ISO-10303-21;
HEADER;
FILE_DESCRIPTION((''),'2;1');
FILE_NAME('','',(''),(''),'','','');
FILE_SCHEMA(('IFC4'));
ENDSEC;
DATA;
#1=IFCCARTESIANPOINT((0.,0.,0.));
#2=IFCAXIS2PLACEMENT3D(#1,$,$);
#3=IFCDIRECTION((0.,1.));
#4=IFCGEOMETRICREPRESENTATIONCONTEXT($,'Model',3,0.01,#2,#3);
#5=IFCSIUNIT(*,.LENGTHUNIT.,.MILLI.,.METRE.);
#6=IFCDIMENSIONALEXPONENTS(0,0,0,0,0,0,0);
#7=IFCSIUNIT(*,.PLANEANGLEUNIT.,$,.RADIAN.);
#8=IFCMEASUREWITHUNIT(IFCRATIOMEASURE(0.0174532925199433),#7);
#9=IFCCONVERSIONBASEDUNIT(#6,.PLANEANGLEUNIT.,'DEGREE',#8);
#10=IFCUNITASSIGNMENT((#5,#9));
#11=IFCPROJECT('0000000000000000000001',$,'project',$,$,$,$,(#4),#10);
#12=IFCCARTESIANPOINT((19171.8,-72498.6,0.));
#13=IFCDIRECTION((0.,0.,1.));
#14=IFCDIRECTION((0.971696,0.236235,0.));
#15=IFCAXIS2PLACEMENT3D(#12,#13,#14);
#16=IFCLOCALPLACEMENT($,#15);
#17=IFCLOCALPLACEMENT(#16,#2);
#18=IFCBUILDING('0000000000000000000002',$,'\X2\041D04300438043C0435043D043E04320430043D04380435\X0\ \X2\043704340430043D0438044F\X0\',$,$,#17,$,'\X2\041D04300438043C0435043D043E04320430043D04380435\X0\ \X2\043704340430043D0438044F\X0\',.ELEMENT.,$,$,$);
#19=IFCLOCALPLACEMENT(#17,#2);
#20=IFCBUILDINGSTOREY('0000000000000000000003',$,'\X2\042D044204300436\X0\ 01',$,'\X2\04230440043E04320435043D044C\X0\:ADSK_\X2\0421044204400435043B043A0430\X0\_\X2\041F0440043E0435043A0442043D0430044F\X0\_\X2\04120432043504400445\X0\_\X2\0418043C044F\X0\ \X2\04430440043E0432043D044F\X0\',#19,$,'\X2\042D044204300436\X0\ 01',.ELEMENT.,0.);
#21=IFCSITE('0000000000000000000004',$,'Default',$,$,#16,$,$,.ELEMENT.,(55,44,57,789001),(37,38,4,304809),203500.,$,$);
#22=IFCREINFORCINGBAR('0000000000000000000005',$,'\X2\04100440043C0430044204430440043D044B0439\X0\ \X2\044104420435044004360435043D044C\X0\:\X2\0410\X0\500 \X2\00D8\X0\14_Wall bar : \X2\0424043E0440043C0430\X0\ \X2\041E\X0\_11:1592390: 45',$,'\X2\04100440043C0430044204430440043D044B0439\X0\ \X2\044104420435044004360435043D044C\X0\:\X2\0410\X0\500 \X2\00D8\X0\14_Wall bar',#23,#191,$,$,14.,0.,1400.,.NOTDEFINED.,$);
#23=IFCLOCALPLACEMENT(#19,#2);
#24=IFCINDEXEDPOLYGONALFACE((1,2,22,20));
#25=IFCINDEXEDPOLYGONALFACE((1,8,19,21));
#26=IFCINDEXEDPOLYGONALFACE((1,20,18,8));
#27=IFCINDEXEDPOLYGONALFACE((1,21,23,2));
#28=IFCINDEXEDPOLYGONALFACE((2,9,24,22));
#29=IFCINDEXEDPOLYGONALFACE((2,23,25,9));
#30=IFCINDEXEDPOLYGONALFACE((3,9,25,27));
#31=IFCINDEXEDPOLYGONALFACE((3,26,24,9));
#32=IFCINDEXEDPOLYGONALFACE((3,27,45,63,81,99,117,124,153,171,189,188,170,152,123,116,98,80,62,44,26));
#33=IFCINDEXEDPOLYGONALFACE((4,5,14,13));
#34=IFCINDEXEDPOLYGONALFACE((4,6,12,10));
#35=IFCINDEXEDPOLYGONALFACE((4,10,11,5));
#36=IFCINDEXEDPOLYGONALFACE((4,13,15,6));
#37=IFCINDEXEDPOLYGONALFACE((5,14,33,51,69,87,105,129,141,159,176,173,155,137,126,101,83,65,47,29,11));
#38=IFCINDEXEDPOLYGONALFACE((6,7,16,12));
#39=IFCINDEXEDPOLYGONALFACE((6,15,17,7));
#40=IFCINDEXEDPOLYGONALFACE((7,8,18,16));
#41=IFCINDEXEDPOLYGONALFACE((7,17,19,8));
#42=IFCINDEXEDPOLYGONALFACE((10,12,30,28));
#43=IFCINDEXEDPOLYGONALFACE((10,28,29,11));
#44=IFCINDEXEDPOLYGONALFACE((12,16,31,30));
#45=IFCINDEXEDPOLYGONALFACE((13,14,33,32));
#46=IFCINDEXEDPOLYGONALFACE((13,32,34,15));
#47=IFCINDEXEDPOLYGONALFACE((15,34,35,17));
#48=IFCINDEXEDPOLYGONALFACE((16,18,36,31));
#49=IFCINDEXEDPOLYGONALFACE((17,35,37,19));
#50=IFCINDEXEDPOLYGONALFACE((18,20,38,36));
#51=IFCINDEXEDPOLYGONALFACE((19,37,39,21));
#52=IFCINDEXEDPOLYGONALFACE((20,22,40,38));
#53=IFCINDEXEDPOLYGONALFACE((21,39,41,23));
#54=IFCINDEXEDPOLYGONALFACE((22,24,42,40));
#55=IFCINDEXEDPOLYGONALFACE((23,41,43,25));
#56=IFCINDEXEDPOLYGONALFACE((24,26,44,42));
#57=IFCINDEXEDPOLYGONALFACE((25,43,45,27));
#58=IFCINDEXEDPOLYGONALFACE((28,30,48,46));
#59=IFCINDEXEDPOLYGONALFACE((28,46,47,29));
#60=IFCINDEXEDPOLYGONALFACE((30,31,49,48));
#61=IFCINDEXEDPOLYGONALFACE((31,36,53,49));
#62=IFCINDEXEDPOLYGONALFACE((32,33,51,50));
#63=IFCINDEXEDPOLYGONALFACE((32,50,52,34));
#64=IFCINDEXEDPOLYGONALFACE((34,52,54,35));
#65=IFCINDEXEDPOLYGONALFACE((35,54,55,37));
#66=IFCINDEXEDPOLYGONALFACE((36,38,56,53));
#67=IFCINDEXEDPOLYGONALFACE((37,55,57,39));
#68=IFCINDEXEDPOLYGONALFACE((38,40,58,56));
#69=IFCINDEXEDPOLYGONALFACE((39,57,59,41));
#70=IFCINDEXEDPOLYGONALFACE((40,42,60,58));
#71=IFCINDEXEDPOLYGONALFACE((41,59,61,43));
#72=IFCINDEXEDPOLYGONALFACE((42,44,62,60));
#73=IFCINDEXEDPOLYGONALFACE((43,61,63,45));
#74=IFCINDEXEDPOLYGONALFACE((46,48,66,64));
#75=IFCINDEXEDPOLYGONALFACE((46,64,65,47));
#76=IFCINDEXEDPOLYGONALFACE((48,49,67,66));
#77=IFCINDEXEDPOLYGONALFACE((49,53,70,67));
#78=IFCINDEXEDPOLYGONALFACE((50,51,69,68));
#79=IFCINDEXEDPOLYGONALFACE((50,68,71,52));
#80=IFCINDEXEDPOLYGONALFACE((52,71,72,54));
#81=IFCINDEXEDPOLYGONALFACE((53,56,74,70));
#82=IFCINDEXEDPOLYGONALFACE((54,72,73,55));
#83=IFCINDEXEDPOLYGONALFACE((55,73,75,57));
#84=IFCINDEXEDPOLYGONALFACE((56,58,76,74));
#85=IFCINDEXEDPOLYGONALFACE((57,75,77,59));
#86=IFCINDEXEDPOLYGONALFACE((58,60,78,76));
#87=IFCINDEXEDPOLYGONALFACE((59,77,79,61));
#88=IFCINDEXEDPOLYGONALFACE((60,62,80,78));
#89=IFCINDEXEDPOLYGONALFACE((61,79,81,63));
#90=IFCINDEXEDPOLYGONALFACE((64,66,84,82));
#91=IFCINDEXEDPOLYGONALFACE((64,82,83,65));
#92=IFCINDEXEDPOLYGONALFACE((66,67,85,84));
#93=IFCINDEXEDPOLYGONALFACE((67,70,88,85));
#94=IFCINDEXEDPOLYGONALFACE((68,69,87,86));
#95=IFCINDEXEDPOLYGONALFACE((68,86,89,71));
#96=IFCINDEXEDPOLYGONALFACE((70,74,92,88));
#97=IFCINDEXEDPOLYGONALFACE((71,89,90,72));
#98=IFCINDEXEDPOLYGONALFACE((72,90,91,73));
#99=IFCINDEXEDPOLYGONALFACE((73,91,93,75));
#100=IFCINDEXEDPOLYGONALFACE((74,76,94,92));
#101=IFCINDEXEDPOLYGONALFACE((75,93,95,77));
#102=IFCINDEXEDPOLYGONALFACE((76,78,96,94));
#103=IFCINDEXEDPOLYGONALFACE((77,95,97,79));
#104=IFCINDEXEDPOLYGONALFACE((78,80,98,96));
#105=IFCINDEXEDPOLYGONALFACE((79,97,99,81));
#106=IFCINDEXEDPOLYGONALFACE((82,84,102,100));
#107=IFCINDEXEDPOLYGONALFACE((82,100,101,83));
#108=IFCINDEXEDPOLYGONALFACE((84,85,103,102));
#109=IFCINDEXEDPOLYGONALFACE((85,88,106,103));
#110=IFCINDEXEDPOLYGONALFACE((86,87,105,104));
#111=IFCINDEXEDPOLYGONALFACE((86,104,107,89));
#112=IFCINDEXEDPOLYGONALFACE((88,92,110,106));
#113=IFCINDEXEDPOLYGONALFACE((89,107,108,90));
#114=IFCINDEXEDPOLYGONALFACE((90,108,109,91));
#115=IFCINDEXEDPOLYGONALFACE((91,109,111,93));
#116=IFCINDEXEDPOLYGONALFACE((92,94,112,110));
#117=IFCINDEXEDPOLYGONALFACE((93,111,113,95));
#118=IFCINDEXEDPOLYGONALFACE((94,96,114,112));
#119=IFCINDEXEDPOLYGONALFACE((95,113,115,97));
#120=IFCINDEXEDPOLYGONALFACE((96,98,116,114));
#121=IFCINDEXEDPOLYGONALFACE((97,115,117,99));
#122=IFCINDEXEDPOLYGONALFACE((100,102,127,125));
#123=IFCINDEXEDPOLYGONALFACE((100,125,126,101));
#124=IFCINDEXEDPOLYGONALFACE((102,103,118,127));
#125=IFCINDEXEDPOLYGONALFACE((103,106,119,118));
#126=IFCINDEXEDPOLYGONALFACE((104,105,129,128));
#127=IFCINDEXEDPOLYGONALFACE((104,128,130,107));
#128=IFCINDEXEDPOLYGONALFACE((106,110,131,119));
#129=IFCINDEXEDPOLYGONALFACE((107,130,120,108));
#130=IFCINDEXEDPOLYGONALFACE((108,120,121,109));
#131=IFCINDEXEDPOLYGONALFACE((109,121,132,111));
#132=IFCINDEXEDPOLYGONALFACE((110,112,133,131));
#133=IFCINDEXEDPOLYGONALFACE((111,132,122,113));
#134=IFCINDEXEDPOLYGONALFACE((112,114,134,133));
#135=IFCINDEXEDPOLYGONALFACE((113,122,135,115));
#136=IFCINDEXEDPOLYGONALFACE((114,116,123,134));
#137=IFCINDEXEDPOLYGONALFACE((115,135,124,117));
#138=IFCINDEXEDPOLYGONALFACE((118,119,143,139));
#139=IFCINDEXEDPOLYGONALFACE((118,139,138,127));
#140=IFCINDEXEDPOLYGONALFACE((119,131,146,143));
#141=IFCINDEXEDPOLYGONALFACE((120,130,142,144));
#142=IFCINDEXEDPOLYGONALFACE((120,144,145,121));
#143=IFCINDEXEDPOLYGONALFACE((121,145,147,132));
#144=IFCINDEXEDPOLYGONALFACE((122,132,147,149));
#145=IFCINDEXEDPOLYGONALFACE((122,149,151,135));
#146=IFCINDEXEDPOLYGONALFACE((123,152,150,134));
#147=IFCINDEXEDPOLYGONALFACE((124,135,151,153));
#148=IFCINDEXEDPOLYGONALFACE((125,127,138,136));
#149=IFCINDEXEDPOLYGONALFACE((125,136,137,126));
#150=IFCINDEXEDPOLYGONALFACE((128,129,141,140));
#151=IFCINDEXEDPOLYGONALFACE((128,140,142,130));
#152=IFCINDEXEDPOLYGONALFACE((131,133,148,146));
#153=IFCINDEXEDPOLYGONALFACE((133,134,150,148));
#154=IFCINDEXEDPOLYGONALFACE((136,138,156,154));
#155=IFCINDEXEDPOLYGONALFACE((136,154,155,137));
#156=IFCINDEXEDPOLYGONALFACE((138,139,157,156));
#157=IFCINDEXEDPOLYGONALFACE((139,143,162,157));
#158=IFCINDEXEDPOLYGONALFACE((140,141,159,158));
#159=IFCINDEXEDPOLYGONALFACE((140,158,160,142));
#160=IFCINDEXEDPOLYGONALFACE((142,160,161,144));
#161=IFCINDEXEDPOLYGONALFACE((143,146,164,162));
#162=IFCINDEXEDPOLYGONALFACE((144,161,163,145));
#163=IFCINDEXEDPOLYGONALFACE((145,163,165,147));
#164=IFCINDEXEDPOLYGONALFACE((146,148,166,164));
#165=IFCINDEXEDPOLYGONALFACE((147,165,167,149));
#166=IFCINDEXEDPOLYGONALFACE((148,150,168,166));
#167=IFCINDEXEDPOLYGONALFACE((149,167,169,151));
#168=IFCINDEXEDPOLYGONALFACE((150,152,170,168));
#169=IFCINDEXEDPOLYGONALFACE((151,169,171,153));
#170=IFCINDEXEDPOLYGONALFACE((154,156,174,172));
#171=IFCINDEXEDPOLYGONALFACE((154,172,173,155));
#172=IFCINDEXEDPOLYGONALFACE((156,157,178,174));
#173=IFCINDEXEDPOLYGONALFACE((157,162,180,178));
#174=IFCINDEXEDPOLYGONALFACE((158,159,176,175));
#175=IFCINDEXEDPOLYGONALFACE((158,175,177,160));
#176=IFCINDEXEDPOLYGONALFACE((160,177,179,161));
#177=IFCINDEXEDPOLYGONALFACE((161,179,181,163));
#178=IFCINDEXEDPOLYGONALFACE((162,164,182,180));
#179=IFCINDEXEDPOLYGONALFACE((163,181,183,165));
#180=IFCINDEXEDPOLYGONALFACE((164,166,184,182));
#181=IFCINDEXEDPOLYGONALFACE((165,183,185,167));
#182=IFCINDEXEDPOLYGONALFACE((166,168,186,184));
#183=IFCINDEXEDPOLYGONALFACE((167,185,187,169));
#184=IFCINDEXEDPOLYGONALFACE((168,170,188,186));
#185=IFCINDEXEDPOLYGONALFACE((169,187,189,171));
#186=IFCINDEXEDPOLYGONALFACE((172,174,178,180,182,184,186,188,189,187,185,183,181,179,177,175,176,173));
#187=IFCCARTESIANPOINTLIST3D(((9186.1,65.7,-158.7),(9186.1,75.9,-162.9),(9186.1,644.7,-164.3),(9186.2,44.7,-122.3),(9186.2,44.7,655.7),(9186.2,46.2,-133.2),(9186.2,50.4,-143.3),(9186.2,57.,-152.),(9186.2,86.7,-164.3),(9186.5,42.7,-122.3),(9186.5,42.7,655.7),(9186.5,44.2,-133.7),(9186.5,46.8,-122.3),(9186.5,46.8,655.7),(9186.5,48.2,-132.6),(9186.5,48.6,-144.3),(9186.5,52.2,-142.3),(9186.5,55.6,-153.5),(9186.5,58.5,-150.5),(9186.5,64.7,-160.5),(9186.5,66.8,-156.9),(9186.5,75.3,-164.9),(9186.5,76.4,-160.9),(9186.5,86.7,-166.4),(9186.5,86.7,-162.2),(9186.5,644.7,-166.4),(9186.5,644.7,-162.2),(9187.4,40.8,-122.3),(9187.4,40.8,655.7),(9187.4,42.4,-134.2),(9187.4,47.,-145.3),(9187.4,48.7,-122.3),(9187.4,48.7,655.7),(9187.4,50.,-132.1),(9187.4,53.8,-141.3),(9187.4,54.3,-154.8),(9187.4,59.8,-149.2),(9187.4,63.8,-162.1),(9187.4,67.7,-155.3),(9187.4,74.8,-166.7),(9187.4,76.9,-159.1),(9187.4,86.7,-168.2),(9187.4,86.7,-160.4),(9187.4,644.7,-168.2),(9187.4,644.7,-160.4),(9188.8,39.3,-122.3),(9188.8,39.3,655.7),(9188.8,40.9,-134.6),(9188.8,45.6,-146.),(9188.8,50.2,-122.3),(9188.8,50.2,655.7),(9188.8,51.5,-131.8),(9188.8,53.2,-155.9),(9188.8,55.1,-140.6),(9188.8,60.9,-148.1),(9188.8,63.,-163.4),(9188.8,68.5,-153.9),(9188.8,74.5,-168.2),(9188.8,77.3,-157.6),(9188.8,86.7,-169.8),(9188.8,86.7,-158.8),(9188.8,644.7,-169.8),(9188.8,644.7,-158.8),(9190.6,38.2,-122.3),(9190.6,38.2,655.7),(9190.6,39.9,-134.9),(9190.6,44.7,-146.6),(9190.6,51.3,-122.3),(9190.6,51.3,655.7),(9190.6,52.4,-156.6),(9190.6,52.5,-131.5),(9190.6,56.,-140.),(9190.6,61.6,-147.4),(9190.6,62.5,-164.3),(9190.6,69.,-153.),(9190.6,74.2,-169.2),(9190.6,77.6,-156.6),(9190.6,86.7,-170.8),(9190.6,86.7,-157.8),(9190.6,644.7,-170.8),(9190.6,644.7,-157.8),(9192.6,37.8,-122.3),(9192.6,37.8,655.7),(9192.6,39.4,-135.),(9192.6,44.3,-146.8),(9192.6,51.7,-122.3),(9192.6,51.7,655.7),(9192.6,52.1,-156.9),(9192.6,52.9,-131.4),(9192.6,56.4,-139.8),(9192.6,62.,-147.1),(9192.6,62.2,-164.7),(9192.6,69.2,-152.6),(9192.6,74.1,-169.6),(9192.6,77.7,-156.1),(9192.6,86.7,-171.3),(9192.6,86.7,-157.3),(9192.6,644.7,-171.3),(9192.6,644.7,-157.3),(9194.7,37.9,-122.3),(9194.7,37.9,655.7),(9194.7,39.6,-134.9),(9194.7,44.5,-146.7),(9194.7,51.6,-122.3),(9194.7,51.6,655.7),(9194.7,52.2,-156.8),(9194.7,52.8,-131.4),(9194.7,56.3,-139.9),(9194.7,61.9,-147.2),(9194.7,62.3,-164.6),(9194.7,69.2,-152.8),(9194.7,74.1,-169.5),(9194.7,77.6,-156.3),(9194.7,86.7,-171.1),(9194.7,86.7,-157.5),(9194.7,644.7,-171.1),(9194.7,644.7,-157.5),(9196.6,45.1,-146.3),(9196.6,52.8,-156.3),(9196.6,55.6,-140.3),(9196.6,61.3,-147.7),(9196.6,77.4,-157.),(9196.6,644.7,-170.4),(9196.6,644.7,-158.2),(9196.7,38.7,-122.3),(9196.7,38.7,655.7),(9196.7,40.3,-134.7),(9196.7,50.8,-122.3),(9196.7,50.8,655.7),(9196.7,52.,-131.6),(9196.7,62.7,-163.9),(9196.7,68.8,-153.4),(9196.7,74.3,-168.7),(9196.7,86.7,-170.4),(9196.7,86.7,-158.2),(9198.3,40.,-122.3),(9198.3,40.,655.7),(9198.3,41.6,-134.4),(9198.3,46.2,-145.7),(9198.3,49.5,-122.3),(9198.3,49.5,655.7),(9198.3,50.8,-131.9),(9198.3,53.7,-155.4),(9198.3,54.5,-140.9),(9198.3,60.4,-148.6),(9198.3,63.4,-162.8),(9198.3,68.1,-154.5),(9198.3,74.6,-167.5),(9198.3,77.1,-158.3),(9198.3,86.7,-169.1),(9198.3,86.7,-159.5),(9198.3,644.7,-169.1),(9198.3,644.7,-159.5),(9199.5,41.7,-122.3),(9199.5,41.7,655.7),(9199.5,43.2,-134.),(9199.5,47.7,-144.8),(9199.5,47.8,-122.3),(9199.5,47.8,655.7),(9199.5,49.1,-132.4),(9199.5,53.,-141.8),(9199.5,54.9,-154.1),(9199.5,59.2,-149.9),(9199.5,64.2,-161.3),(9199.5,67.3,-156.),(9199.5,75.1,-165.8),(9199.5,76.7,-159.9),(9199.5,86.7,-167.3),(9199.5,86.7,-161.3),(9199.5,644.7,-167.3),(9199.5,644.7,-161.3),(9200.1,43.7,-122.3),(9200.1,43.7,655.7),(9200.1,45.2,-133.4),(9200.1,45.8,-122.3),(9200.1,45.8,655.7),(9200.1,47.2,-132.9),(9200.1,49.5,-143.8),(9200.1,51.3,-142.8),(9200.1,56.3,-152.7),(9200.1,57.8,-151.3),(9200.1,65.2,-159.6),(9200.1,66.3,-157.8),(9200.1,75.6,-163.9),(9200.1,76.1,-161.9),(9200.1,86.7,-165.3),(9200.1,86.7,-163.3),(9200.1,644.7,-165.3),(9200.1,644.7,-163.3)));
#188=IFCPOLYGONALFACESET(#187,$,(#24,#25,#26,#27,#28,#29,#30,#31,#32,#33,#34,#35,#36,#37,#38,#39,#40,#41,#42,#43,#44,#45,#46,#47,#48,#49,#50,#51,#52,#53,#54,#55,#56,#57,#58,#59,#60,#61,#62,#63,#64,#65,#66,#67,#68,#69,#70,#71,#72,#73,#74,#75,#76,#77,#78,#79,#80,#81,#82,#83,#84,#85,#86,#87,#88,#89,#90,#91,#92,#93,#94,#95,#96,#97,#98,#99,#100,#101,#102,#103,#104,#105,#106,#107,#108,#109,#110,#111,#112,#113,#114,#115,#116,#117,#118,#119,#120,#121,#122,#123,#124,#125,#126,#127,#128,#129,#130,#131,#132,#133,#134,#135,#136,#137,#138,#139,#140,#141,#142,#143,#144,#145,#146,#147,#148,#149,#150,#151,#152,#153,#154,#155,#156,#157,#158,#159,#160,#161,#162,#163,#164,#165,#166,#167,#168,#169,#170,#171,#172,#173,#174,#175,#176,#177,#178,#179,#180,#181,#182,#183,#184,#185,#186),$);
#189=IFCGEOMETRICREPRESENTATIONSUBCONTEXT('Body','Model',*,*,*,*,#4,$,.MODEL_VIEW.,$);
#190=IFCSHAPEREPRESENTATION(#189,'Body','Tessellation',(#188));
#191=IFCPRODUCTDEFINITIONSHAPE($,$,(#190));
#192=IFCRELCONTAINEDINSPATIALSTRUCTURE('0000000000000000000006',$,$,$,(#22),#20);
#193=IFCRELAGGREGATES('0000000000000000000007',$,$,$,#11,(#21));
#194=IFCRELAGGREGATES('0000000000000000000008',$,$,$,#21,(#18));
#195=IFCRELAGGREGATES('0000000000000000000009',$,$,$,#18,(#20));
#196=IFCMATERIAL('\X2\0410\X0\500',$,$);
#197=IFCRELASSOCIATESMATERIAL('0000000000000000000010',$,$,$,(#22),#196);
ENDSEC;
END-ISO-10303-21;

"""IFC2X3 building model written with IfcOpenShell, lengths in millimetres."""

from ifc_helpers import new_model, entity, si_unit, converted_unit, direction, frame, origin, place, context, subcontext, project, spatial, material, element, save


model = new_model("IFC2X3")

# Units and contexts
model_context = context("Model", 3, precision=0.01, world=origin(), true_north=direction((0.0, 1.0)))
body_context = subcontext(model_context, "Body", "Model", "MODEL_VIEW")
ifc_project = project(units=[si_unit("LENGTHUNIT", "METRE", prefix="MILLI"), converted_unit("PLANEANGLEUNIT", "DEGREE", entity("IfcRatioMeasure", 0.0174532925199433), si_unit("PLANEANGLEUNIT", "RADIAN"), dimensions=[0, 0, 0, 0, 0, 0, 0])], contexts=[model_context])

# Site, building, storey
site_placement = place(None, frame((19171.8, -72498.6, 0.0), z_axis=(0.0, 0.0, 1.0), x_axis=(0.971696, 0.236235, 0.0)))
site = spatial("IfcSite", under=ifc_project, at=site_placement, Name="Default", CompositionType="ELEMENT", RefLatitude=(55, 44, 57, 789001), RefLongitude=(37, 38, 4, 304809), RefElevation=203500.0)
building_placement = place(site_placement, origin())
building = spatial("IfcBuilding", under=site, at=building_placement, Name="Наименование здания", LongName="Наименование здания", CompositionType="ELEMENT")
storey_placement = place(building_placement, origin())
storey = spatial("IfcBuildingStorey", under=building, at=storey_placement, Name="Этаж 01", ObjectType="Уровень:ADSK_Стрелка_Проектная_Вверх_Имя уровня", LongName="Этаж 01", CompositionType="ELEMENT", Elevation=0.0)

# Reinforcing bar
ifc_material = material(Name="А500")
placement = place(storey_placement, origin())
element("IfcReinforcingBar", 1, at=placement, inside=storey, material=ifc_material, Name="Арматурный стержень:А500 Ø14_Wall bar : Форма О_11:1592390: 45", ObjectType="Арматурный стержень:А500 Ø14_Wall bar", BarLength=1400.0, BarRole="NOTDEFINED", CrossSectionArea=0.0, NominalDiameter=14.0, context=body_context, shape_type="AdvancedSweptSolid", body=[
    entity("IfcSweptDiskSolid", entity("IfcCompositeCurve", [entity("IfcCompositeCurveSegment", "CONTINUOUS", True, entity("IfcPolyline", [entity("IfcCartesianPoint", [9193.1, 44.7, 655.7]), entity("IfcCartesianPoint", [9193.1, 44.7, -122.3])])), entity("IfcCompositeCurveSegment", "CONTINUOUS", True, entity("IfcTrimmedCurve", entity("IfcCircle", entity("IfcAxis2Placement3D", entity("IfcCartesianPoint", [9193.1, 86.7, -122.3]), entity("IfcDirection", [1.0, 0.0, 0.0]), entity("IfcDirection", [0.0, 0.0, -1.0])), 42.0), [entity("IfcParameterValue", 270.0)], [entity("IfcParameterValue", 360.0)], True, "PARAMETER")), entity("IfcCompositeCurveSegment", "CONTINUOUS", True, entity("IfcPolyline", [entity("IfcCartesianPoint", [9193.1, 86.7, -164.3]), entity("IfcCartesianPoint", [9193.1, 644.7, -164.3])]))], False), 7.0, None, 0.0, 92.0),
])

save(model, "model.ifc")
